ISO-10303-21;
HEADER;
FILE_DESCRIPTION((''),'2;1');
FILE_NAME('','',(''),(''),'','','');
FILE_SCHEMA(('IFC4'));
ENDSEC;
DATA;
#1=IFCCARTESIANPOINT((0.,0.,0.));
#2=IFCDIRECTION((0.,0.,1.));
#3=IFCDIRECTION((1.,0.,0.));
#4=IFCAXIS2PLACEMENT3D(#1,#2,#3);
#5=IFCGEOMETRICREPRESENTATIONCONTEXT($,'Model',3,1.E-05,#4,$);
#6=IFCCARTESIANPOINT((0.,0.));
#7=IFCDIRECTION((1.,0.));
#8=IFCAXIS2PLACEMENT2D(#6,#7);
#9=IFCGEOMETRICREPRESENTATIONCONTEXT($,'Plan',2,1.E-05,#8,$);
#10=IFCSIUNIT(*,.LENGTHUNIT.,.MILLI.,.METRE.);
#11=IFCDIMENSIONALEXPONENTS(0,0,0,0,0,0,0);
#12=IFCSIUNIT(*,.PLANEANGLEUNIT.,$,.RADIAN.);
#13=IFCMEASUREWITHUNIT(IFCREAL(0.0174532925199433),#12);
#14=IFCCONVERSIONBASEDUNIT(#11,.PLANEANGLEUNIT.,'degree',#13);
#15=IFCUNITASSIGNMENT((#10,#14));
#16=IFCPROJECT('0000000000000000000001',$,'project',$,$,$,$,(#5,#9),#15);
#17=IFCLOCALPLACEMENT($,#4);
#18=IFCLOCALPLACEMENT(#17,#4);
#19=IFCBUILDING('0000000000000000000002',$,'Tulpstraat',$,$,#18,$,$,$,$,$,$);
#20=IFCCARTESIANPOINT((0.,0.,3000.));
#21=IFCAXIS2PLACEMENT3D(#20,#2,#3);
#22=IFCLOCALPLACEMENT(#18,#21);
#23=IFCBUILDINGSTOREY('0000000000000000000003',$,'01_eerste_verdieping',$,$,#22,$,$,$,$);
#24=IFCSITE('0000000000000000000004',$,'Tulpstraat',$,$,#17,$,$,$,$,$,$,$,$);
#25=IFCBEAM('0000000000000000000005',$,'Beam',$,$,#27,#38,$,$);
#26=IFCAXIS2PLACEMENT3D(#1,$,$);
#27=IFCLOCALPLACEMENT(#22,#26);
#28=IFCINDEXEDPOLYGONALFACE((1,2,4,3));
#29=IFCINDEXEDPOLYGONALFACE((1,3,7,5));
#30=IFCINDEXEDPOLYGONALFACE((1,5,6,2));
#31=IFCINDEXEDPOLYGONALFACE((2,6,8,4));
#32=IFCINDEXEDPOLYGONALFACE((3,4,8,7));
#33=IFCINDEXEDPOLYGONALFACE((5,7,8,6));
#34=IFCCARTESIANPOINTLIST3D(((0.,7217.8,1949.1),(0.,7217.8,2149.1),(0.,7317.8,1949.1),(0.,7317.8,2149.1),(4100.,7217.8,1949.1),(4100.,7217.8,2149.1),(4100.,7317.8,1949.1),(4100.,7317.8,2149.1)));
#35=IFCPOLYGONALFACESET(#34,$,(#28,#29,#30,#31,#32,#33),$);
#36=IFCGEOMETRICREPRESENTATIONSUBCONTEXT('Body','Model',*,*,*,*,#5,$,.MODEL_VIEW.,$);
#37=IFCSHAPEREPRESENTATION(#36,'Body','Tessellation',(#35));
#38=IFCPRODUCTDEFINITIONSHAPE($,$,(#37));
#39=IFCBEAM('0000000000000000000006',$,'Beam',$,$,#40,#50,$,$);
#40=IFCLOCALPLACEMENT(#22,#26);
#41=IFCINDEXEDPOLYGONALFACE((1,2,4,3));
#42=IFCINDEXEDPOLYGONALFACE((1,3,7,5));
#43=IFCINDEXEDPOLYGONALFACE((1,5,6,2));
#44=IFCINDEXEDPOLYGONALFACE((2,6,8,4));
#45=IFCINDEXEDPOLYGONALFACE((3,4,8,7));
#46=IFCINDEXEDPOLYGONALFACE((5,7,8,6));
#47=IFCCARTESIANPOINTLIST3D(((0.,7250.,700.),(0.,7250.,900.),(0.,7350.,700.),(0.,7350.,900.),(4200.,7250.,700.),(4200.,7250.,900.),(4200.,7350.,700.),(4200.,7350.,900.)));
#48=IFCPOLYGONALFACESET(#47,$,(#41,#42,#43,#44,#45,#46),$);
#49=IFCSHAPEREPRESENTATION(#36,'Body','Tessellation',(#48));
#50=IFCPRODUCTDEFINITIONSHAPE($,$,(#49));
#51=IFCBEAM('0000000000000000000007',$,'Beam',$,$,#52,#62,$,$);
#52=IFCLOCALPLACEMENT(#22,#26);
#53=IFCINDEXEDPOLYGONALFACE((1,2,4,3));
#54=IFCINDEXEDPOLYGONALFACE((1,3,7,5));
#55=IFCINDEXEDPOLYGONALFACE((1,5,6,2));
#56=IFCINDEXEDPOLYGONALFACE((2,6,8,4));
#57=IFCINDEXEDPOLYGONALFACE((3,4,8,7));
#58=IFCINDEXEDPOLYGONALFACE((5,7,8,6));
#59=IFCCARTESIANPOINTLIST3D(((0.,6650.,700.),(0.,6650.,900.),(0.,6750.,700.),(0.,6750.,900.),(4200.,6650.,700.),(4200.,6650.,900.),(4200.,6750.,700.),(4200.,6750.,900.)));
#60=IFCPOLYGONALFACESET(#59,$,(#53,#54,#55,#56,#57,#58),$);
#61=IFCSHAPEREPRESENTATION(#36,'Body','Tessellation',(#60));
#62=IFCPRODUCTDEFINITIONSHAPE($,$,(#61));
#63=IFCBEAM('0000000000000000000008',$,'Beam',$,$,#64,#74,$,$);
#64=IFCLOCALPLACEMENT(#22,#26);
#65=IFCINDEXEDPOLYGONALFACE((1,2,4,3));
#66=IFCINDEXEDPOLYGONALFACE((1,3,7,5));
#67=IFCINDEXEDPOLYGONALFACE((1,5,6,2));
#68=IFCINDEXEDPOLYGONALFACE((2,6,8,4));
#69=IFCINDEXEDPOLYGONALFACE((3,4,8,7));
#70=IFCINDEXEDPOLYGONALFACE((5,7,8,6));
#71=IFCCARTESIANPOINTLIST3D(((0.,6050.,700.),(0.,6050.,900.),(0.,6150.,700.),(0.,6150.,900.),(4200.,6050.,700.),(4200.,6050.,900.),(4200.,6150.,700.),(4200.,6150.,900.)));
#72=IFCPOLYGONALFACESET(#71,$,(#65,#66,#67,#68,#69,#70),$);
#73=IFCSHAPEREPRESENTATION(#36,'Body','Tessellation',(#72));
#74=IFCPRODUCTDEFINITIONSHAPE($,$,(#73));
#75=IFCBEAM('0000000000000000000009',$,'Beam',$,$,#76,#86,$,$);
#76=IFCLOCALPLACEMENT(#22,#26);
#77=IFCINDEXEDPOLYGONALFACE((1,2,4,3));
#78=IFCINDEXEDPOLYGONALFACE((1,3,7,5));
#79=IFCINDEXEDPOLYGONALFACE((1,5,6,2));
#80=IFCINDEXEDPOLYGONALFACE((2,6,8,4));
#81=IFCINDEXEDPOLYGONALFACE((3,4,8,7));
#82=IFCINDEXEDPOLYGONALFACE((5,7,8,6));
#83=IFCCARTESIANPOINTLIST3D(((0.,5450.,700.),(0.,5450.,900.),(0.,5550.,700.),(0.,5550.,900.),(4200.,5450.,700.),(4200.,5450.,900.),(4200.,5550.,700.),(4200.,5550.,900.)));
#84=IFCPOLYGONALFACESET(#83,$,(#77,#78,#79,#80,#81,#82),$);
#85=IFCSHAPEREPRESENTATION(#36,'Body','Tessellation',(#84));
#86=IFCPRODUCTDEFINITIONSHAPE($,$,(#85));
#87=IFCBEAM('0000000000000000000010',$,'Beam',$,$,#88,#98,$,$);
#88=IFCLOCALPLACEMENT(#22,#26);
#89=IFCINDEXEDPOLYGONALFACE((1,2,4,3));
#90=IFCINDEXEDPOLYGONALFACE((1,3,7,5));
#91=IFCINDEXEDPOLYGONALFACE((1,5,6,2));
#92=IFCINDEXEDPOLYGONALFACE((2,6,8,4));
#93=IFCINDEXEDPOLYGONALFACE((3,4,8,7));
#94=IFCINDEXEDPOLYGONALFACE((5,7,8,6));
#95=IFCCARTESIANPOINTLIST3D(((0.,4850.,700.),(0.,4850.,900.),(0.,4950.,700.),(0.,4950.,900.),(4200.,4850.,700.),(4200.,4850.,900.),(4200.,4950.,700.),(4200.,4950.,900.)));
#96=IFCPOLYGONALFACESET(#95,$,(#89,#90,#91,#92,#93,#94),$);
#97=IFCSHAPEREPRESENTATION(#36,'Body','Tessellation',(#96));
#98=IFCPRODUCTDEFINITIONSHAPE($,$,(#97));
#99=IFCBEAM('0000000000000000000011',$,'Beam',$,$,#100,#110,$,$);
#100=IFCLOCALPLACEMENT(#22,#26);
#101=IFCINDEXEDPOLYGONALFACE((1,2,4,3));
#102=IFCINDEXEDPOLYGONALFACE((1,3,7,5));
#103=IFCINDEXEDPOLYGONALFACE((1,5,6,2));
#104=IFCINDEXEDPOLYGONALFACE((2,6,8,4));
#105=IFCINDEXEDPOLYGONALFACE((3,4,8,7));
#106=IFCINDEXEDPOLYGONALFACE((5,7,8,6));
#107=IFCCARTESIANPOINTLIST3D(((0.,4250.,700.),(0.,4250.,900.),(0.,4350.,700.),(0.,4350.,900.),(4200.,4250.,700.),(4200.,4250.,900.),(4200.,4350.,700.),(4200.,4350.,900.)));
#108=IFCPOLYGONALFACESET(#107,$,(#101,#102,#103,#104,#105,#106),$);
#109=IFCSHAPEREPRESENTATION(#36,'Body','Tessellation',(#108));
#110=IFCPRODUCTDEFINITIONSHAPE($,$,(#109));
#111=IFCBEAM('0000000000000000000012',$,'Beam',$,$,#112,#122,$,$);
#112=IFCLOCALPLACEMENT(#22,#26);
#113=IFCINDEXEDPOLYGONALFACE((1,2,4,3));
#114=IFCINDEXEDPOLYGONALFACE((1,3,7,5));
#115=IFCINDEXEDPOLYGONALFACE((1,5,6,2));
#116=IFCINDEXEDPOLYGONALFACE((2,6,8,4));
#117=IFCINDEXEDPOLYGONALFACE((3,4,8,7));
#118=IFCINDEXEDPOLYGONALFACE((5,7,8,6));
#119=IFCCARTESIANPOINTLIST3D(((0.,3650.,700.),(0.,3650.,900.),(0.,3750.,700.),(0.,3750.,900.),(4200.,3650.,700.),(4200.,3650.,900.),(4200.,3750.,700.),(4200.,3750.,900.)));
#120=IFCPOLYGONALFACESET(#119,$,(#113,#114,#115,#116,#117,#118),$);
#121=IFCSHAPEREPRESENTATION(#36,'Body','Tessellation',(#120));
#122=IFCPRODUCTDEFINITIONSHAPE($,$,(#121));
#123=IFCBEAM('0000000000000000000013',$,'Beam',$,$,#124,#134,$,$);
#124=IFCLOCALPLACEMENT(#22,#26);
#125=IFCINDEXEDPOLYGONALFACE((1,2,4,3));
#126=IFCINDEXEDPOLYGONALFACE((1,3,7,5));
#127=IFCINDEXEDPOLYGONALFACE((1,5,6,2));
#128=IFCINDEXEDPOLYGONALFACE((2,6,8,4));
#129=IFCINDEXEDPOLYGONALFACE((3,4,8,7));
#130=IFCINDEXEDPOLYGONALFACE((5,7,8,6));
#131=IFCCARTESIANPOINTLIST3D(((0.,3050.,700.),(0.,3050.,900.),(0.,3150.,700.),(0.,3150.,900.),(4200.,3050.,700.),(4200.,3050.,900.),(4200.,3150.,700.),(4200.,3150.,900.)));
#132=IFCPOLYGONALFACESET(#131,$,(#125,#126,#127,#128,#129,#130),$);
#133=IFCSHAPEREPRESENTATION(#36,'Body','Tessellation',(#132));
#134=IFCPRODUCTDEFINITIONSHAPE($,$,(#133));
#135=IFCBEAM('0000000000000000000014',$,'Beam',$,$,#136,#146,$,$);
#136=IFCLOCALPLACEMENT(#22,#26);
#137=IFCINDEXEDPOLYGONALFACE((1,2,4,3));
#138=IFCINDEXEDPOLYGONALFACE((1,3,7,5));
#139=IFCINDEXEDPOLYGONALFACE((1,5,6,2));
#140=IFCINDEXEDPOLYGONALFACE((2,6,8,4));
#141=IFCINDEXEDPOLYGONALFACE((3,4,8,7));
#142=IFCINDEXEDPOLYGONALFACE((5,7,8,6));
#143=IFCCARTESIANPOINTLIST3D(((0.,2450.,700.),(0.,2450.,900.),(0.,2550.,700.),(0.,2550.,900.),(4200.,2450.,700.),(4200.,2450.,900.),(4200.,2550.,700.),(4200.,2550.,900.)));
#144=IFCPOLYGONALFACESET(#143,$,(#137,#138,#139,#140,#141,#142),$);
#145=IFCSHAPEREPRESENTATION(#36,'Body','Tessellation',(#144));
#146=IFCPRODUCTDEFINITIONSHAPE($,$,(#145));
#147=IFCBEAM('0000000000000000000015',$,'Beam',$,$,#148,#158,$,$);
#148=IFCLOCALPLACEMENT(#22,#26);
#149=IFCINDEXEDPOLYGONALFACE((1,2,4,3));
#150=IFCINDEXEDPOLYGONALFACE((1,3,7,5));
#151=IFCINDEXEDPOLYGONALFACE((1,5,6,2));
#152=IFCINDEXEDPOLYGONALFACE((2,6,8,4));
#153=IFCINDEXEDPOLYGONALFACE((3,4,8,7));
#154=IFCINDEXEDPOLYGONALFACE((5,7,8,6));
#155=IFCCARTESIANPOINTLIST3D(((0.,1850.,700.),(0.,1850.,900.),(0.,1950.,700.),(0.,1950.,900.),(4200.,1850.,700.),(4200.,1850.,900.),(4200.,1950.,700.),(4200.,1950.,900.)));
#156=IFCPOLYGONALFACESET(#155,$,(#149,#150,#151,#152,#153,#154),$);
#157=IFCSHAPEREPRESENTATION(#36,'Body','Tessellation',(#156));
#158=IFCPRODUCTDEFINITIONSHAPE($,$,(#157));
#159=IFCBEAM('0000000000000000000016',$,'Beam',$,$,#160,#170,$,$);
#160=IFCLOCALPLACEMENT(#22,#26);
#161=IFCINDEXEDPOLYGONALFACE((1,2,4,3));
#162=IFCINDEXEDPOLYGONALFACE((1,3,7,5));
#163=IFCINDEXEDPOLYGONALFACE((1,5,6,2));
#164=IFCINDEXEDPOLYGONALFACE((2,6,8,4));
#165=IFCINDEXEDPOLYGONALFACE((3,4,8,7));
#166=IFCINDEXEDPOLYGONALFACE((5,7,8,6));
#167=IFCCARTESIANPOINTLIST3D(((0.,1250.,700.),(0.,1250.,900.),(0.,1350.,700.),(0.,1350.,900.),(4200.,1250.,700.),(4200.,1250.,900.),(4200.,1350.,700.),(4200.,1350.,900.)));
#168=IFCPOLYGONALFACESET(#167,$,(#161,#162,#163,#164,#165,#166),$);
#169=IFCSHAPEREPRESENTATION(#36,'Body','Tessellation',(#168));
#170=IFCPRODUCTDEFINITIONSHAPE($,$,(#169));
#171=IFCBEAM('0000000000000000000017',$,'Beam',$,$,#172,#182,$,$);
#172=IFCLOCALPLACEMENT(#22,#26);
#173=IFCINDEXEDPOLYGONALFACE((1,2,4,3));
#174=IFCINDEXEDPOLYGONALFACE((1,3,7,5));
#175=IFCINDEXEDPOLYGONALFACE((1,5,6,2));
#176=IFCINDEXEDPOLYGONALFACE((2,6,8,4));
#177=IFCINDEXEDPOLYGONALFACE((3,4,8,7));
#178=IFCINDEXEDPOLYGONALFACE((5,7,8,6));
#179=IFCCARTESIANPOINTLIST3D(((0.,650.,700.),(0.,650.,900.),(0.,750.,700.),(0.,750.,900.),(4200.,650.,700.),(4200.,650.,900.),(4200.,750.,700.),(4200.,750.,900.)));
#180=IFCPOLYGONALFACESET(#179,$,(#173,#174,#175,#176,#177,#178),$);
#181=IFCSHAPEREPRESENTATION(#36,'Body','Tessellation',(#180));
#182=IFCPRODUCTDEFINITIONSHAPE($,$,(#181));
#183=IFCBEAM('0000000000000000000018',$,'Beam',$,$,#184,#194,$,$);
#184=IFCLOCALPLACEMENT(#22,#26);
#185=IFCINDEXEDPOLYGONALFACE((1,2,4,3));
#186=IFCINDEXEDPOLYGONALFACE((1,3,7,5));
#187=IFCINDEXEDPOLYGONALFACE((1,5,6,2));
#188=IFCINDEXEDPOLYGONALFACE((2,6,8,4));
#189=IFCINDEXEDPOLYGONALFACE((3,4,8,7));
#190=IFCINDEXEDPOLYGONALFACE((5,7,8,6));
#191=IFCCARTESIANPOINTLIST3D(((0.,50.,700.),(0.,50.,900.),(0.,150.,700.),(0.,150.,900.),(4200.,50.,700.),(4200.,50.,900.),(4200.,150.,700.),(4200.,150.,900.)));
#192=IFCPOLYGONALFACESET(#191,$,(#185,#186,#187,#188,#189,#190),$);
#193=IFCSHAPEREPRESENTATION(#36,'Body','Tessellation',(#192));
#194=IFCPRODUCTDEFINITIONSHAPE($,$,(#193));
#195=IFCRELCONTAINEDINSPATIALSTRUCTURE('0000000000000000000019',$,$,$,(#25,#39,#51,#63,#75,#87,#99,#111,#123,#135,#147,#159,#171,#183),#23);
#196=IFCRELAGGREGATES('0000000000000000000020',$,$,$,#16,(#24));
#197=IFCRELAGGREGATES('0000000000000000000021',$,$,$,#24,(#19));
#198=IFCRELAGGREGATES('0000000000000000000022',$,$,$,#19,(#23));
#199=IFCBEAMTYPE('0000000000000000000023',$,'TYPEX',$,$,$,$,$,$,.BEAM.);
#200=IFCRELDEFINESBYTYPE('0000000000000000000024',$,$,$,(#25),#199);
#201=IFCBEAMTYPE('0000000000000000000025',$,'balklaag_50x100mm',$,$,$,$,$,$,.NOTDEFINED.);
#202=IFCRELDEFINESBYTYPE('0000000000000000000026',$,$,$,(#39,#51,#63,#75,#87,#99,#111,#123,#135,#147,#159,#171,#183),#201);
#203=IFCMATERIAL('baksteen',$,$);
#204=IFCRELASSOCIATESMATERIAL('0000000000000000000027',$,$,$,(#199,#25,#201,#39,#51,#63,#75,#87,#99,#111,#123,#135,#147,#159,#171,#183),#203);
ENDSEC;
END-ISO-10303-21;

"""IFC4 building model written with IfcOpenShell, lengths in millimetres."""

from ifc_helpers import new_model, entity, si_unit, converted_unit, frame, origin_with_axes, origin_2d_with_axis, place, context, subcontext, project, spatial, rectangle, extrude, material, material_profile, profile_set, profile_usage, type_object, element, save


model = new_model("IFC4")

# Units and contexts
model_context = context("Model", 3, precision=1e-05, world=origin_with_axes())
plan_context = context("Plan", 2, precision=1e-05, world=origin_2d_with_axis())
body_context = subcontext(model_context, "Body", "Model", "MODEL_VIEW")
ifc_project = project(units=[si_unit("LENGTHUNIT", "METRE", prefix="MILLI"), converted_unit("PLANEANGLEUNIT", "degree", entity("IfcReal", 0.0174532925199433), si_unit("PLANEANGLEUNIT", "RADIAN"), dimensions=[0, 0, 0, 0, 0, 0, 0])], contexts=[model_context, plan_context])

# Site, building, storey
site_placement = place(None, origin_with_axes())
site = spatial("IfcSite", under=ifc_project, at=site_placement, Name="Tulpstraat")
building_placement = place(site_placement, origin_with_axes())
building = spatial("IfcBuilding", under=site, at=building_placement, Name="Tulpstraat")
storey_placement = place(building_placement, frame((0.0, 0.0, 3000.0), z_axis=(0.0, 0.0, 1.0), x_axis=(1.0, 0.0, 0.0)))
storey = spatial("IfcBuildingStorey", under=building, at=storey_placement, Name="01_eerste_verdieping")

# Beams
ifc_material = material(Name="baksteen")
ifc_material_profile_1 = material_profile(ifc_material, rectangle(XDim=100.0, YDim=200.0))
ifc_profile_set_1 = profile_set([ifc_material_profile_1])
ifc_profile_usage_1 = profile_usage(ifc_profile_set_1, cardinal=5)
beam_type_1 = type_object("IfcBeamType", Name="TYPEX", PredefinedType="BEAM", material=ifc_profile_set_1)
beam_1_placement = place(storey_placement, frame((0.0, 7267.8, 2049.1), z_axis=(1.0, 0.0, 0.0), x_axis=(0.0, 1.0, 0.0)))
element("IfcBeam", 1, at=beam_1_placement, inside=storey, type_object=beam_type_1, material=ifc_profile_usage_1, Name="Beam", context=body_context, shape_type="SweptSolid", body=[
    extrude(rectangle(XDim=100.0, YDim=200.0), origin_with_axes(), (0.0, 0.0, 1.0), 4100.0),
])
ifc_material_profile_2 = material_profile(ifc_material, rectangle(XDim=100.0, YDim=200.0))
ifc_profile_set_2 = profile_set([ifc_material_profile_2])
ifc_profile_usage_2 = profile_usage(ifc_profile_set_2, cardinal=5)
beam_type_2 = type_object("IfcBeamType", Name="balklaag_50x100mm", PredefinedType="NOTDEFINED", material=ifc_profile_set_2)
beam_2_placement = place(storey_placement, frame((4200.0, 7300.0, 800.0), z_axis=(-1.0, 0.0, 0.0), x_axis=(0.0, -1.0, 0.0)))
element("IfcBeam", 2, at=beam_2_placement, inside=storey, type_object=beam_type_2, material=ifc_profile_usage_2, Name="Beam", context=body_context, shape_type="SweptSolid", body=[
    extrude(rectangle(XDim=100.0, YDim=200.0), origin_with_axes(), (0.0, 0.0, 1.0), 4200.0),
])
ifc_profile_usage_3 = profile_usage(ifc_profile_set_2, cardinal=5)
beam_3_placement = place(storey_placement, frame((4200.0, 6700.0, 800.0), z_axis=(-1.0, 0.0, 0.0), x_axis=(0.0, -1.0, 0.0)))
element("IfcBeam", 3, at=beam_3_placement, inside=storey, type_object=beam_type_2, material=ifc_profile_usage_3, Name="Beam", context=body_context, shape_type="SweptSolid", body=[
    extrude(rectangle(XDim=100.0, YDim=200.0), origin_with_axes(), (0.0, 0.0, 1.0), 4200.0),
])
ifc_profile_usage_4 = profile_usage(ifc_profile_set_2, cardinal=5)
beam_4_placement = place(storey_placement, frame((4200.0, 6100.0, 800.0), z_axis=(-1.0, 0.0, 0.0), x_axis=(0.0, -1.0, 0.0)))
element("IfcBeam", 4, at=beam_4_placement, inside=storey, type_object=beam_type_2, material=ifc_profile_usage_4, Name="Beam", context=body_context, shape_type="SweptSolid", body=[
    extrude(rectangle(XDim=100.0, YDim=200.0), origin_with_axes(), (0.0, 0.0, 1.0), 4200.0),
])
ifc_profile_usage_5 = profile_usage(ifc_profile_set_2, cardinal=5)
beam_5_placement = place(storey_placement, frame((4200.0, 5500.0, 800.0), z_axis=(-1.0, 0.0, 0.0), x_axis=(0.0, -1.0, 0.0)))
element("IfcBeam", 5, at=beam_5_placement, inside=storey, type_object=beam_type_2, material=ifc_profile_usage_5, Name="Beam", context=body_context, shape_type="SweptSolid", body=[
    extrude(rectangle(XDim=100.0, YDim=200.0), origin_with_axes(), (0.0, 0.0, 1.0), 4200.0),
])
ifc_profile_usage_6 = profile_usage(ifc_profile_set_2, cardinal=5)
beam_6_placement = place(storey_placement, frame((4200.0, 4900.0, 800.0), z_axis=(-1.0, 0.0, 0.0), x_axis=(0.0, -1.0, 0.0)))
element("IfcBeam", 6, at=beam_6_placement, inside=storey, type_object=beam_type_2, material=ifc_profile_usage_6, Name="Beam", context=body_context, shape_type="SweptSolid", body=[
    extrude(rectangle(XDim=100.0, YDim=200.0), origin_with_axes(), (0.0, 0.0, 1.0), 4200.0),
])
ifc_profile_usage_7 = profile_usage(ifc_profile_set_2, cardinal=5)
beam_7_placement = place(storey_placement, frame((4200.0, 4300.0, 800.0), z_axis=(-1.0, 0.0, 0.0), x_axis=(0.0, -1.0, 0.0)))
element("IfcBeam", 7, at=beam_7_placement, inside=storey, type_object=beam_type_2, material=ifc_profile_usage_7, Name="Beam", context=body_context, shape_type="SweptSolid", body=[
    extrude(rectangle(XDim=100.0, YDim=200.0), origin_with_axes(), (0.0, 0.0, 1.0), 4200.0),
])
ifc_profile_usage_8 = profile_usage(ifc_profile_set_2, cardinal=5)
beam_8_placement = place(storey_placement, frame((4200.0, 3700.0, 800.0), z_axis=(-1.0, 0.0, 0.0), x_axis=(0.0, -1.0, 0.0)))
element("IfcBeam", 8, at=beam_8_placement, inside=storey, type_object=beam_type_2, material=ifc_profile_usage_8, Name="Beam", context=body_context, shape_type="SweptSolid", body=[
    extrude(rectangle(XDim=100.0, YDim=200.0), origin_with_axes(), (0.0, 0.0, 1.0), 4200.0),
])
ifc_profile_usage_9 = profile_usage(ifc_profile_set_2, cardinal=5)
beam_9_placement = place(storey_placement, frame((4200.0, 3100.0, 800.0), z_axis=(-1.0, 0.0, 0.0), x_axis=(0.0, -1.0, 0.0)))
element("IfcBeam", 9, at=beam_9_placement, inside=storey, type_object=beam_type_2, material=ifc_profile_usage_9, Name="Beam", context=body_context, shape_type="SweptSolid", body=[
    extrude(rectangle(XDim=100.0, YDim=200.0), origin_with_axes(), (0.0, 0.0, 1.0), 4200.0),
])
ifc_profile_usage_10 = profile_usage(ifc_profile_set_2, cardinal=5)
beam_10_placement = place(storey_placement, frame((4200.0, 2500.0, 800.0), z_axis=(-1.0, 0.0, 0.0), x_axis=(0.0, -1.0, 0.0)))
element("IfcBeam", 10, at=beam_10_placement, inside=storey, type_object=beam_type_2, material=ifc_profile_usage_10, Name="Beam", context=body_context, shape_type="SweptSolid", body=[
    extrude(rectangle(XDim=100.0, YDim=200.0), origin_with_axes(), (0.0, 0.0, 1.0), 4200.0),
])
ifc_profile_usage_11 = profile_usage(ifc_profile_set_2, cardinal=5)
beam_11_placement = place(storey_placement, frame((4200.0, 1900.0, 800.0), z_axis=(-1.0, 0.0, 0.0), x_axis=(0.0, -1.0, 0.0)))
element("IfcBeam", 11, at=beam_11_placement, inside=storey, type_object=beam_type_2, material=ifc_profile_usage_11, Name="Beam", context=body_context, shape_type="SweptSolid", body=[
    extrude(rectangle(XDim=100.0, YDim=200.0), origin_with_axes(), (0.0, 0.0, 1.0), 4200.0),
])
ifc_profile_usage_12 = profile_usage(ifc_profile_set_2, cardinal=5)
beam_12_placement = place(storey_placement, frame((4200.0, 1300.0, 800.0), z_axis=(-1.0, 0.0, 0.0), x_axis=(0.0, -1.0, 0.0)))
element("IfcBeam", 12, at=beam_12_placement, inside=storey, type_object=beam_type_2, material=ifc_profile_usage_12, Name="Beam", context=body_context, shape_type="SweptSolid", body=[
    extrude(rectangle(XDim=100.0, YDim=200.0), origin_with_axes(), (0.0, 0.0, 1.0), 4200.0),
])
ifc_profile_usage_13 = profile_usage(ifc_profile_set_2, cardinal=5)
beam_13_placement = place(storey_placement, frame((4200.0, 700.0, 800.0), z_axis=(-1.0, 0.0, 0.0), x_axis=(0.0, -1.0, 0.0)))
element("IfcBeam", 13, at=beam_13_placement, inside=storey, type_object=beam_type_2, material=ifc_profile_usage_13, Name="Beam", context=body_context, shape_type="SweptSolid", body=[
    extrude(rectangle(XDim=100.0, YDim=200.0), origin_with_axes(), (0.0, 0.0, 1.0), 4200.0),
])
ifc_profile_usage_14 = profile_usage(ifc_profile_set_2, cardinal=5)
beam_14_placement = place(storey_placement, frame((4200.0, 100.0, 800.0), z_axis=(-1.0, 0.0, 0.0), x_axis=(0.0, -1.0, 0.0)))
element("IfcBeam", 14, at=beam_14_placement, inside=storey, type_object=beam_type_2, material=ifc_profile_usage_14, Name="Beam", context=body_context, shape_type="SweptSolid", body=[
    extrude(rectangle(XDim=100.0, YDim=200.0), origin_with_axes(), (0.0, 0.0, 1.0), 4200.0),
])

save(model, "model.ifc")
